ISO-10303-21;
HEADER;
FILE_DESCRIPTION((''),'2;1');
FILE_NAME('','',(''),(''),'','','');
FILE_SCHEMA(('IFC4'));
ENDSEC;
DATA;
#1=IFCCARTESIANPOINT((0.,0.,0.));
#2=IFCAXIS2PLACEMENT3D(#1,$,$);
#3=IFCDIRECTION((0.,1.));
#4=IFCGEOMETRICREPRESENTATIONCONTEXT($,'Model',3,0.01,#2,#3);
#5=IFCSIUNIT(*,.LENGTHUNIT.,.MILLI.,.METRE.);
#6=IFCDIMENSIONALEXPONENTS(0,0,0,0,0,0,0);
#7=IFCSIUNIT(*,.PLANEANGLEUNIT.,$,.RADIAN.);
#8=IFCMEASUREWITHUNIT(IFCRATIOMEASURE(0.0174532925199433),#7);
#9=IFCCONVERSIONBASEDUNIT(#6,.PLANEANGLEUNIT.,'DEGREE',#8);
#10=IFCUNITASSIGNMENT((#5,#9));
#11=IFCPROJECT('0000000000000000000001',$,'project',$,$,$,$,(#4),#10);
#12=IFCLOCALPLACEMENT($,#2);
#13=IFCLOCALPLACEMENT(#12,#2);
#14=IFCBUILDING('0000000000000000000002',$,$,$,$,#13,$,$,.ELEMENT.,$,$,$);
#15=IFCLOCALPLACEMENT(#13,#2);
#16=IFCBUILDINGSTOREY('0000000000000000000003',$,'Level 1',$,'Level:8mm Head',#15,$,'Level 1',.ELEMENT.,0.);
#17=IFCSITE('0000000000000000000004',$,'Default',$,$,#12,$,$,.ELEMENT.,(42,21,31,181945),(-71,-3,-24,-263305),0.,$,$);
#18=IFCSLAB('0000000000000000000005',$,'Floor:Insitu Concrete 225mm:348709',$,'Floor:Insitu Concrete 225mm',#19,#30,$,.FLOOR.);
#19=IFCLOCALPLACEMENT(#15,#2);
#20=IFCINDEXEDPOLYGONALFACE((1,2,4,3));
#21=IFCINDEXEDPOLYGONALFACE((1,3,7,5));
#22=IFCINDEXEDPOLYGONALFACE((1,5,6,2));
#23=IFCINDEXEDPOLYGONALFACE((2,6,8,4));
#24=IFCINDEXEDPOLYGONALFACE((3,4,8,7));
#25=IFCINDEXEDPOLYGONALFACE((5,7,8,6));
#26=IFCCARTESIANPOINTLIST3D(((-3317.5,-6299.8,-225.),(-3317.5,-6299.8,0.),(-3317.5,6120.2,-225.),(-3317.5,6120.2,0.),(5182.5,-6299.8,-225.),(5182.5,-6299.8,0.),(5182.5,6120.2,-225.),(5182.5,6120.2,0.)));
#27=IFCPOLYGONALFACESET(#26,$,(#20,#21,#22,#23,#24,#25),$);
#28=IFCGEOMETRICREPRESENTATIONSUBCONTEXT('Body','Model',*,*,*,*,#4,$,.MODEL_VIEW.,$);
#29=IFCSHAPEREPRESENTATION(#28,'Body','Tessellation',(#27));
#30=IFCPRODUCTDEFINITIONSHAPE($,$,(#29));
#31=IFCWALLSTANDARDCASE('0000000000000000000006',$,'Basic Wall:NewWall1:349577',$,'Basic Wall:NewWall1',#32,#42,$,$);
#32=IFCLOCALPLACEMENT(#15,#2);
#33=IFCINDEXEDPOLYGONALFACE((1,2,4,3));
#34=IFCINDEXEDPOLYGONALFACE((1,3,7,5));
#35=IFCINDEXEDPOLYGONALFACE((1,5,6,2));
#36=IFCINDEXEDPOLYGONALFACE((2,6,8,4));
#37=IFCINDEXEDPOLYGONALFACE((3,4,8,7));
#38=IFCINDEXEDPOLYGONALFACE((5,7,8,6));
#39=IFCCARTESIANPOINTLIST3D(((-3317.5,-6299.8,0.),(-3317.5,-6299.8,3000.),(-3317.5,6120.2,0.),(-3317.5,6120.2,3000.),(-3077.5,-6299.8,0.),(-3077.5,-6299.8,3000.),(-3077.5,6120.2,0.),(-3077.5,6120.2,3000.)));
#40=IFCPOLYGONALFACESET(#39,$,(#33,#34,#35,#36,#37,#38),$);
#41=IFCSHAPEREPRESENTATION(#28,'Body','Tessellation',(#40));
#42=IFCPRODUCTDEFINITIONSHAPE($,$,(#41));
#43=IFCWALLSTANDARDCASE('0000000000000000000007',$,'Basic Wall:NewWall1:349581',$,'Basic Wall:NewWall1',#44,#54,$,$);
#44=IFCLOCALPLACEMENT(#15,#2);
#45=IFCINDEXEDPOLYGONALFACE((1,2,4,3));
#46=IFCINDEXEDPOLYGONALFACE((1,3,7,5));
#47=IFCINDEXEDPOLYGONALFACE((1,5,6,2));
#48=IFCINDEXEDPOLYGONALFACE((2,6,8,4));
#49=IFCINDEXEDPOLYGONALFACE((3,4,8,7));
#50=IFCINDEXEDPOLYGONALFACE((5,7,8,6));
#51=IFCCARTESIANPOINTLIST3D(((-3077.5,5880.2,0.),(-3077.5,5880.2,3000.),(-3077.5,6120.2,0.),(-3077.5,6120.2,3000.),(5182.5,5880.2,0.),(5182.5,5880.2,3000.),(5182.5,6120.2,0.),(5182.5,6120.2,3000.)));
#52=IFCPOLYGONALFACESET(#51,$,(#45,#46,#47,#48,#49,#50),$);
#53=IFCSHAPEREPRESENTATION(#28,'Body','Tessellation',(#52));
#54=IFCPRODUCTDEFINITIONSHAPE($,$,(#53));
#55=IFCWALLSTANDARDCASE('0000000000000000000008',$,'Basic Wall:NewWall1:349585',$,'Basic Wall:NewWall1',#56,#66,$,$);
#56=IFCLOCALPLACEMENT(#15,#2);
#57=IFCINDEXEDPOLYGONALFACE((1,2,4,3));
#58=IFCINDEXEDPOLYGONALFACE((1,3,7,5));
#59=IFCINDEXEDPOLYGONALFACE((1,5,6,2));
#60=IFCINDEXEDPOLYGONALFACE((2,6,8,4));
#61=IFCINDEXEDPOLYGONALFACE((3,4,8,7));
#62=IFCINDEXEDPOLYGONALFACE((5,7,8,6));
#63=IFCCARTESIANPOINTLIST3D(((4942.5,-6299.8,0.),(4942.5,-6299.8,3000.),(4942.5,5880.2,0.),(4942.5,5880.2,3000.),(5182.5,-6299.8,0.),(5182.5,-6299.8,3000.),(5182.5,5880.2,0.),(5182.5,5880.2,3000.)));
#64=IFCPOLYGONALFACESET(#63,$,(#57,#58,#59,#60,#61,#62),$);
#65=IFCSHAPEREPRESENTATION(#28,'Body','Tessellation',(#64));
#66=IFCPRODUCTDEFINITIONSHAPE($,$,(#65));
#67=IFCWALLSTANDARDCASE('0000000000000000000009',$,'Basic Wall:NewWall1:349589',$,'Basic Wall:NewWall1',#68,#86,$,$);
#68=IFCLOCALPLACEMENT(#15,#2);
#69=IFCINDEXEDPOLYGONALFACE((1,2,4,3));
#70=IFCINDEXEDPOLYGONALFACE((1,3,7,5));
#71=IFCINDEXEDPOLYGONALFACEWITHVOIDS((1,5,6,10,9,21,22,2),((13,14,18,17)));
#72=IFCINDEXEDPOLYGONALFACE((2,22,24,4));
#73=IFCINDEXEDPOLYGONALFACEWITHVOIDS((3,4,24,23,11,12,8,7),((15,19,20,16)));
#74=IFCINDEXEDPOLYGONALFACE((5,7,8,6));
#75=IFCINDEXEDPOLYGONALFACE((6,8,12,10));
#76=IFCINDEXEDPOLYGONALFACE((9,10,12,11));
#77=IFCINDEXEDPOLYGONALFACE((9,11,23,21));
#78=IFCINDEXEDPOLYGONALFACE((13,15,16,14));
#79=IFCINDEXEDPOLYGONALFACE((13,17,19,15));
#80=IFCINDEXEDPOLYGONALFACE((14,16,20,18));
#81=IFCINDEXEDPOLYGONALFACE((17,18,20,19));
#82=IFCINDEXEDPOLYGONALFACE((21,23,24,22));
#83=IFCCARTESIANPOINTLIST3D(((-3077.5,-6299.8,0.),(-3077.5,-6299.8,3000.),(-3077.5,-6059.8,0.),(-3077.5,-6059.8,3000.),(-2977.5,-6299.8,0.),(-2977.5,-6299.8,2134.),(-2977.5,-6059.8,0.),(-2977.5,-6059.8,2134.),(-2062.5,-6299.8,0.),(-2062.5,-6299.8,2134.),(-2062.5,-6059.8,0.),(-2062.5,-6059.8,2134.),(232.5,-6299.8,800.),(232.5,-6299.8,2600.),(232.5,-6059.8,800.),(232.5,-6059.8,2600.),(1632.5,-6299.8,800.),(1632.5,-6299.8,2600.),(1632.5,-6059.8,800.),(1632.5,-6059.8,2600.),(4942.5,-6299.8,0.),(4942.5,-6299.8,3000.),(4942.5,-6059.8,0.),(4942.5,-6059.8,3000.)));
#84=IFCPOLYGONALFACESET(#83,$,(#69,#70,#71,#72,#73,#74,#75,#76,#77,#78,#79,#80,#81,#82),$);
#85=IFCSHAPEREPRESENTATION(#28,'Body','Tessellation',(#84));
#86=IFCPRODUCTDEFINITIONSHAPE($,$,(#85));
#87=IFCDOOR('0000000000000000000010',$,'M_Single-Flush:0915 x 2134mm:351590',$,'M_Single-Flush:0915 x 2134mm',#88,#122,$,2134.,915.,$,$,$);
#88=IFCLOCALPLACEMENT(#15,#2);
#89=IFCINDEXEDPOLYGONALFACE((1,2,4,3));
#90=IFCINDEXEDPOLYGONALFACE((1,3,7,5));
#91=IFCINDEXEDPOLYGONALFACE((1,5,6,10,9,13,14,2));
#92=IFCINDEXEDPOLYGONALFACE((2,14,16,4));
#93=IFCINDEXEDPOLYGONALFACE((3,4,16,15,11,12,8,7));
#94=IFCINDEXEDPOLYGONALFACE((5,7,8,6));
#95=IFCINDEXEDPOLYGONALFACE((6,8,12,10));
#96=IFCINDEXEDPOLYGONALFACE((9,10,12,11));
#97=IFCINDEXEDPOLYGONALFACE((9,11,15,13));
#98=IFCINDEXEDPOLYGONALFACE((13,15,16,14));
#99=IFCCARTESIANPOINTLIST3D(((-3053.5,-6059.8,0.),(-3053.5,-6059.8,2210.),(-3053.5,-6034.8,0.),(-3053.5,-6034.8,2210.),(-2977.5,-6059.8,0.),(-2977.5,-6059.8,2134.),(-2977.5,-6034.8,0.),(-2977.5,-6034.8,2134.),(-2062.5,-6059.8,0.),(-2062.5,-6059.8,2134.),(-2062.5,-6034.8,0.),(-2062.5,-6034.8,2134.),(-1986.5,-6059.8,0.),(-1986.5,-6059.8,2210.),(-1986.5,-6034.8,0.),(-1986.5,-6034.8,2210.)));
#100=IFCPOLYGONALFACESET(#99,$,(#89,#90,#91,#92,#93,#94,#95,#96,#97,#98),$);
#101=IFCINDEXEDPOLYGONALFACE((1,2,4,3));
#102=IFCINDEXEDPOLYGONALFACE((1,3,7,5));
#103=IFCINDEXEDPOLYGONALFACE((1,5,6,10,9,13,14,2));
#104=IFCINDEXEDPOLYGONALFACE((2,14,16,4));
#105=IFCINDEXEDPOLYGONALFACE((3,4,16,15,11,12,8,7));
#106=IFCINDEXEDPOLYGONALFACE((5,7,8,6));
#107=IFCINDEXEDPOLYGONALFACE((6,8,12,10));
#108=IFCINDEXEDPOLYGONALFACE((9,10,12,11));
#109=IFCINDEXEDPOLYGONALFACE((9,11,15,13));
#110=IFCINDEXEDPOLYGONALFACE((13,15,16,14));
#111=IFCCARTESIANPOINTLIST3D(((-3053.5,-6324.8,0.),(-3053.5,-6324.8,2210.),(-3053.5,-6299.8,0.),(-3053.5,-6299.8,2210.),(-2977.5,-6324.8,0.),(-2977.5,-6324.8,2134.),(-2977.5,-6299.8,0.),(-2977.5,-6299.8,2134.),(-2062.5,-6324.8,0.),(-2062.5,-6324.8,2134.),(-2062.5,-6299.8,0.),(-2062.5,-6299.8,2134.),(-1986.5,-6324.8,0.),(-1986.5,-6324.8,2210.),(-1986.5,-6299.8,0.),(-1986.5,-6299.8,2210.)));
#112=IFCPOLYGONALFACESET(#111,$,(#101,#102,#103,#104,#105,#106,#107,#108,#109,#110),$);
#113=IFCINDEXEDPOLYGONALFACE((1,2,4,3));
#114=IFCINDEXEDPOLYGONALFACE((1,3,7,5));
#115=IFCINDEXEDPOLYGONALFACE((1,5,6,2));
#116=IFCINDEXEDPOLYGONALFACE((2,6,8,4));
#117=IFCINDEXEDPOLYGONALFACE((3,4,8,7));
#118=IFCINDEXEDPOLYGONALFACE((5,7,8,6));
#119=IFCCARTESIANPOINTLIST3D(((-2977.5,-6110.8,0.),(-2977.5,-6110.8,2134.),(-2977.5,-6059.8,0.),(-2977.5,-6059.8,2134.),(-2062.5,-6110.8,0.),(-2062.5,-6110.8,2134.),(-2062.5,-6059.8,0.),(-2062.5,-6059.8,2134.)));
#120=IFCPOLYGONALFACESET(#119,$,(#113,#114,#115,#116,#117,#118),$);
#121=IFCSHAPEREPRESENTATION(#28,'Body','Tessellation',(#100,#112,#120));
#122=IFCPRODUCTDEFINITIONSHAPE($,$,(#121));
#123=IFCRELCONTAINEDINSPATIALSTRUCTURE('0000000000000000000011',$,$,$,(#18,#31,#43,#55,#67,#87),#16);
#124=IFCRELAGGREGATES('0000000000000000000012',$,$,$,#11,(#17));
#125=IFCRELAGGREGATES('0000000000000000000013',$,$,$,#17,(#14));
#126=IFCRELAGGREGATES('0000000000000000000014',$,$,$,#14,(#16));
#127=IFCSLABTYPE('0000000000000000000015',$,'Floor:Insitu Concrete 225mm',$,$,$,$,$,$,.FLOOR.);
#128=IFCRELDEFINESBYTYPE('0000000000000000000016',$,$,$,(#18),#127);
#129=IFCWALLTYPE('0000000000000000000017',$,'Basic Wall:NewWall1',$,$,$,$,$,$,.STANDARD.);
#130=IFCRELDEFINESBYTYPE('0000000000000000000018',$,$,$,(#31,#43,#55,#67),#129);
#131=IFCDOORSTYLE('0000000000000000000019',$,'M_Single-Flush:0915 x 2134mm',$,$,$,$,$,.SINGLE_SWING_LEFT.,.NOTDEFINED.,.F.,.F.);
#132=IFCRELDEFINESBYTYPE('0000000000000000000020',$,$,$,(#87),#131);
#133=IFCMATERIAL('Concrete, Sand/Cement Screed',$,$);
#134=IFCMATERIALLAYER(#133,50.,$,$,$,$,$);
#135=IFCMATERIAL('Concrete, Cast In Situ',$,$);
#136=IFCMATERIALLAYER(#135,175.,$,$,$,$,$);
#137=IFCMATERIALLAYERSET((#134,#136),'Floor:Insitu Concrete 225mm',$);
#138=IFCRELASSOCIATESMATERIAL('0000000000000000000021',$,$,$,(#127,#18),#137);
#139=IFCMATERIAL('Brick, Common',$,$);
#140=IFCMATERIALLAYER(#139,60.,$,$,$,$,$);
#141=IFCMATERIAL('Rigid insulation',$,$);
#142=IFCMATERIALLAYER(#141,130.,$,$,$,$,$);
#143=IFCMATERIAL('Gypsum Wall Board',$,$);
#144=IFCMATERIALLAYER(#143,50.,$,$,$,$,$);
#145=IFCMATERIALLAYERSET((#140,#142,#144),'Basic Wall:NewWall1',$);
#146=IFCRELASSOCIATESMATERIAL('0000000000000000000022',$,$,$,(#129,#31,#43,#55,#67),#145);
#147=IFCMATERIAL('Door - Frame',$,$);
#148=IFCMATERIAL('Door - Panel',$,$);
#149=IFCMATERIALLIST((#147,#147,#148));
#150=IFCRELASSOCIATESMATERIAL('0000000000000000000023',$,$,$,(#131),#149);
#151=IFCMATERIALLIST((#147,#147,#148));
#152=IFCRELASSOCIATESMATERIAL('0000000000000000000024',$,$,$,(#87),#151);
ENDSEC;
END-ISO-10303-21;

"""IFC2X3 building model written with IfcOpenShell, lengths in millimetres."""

from ifc_helpers import new_model, entity, si_unit, converted_unit, direction, frame, frame_2d, origin, place, context, subcontext, project, spatial, polyline, rectangle, outline, extrude, clip, bounded_halfspace, source, transform, mapped, material, material_list, layer, layer_set, layer_usage, type_object, type_shapes, element, fill, save


model = new_model("IFC2X3")

# Units and contexts
model_context = context("Model", 3, precision=0.01, world=origin(), true_north=direction((0.0, 1.0)))
body_context = subcontext(model_context, "Body", "Model", "MODEL_VIEW")
ifc_project = project(units=[si_unit("LENGTHUNIT", "METRE", prefix="MILLI"), converted_unit("PLANEANGLEUNIT", "DEGREE", entity("IfcRatioMeasure", 0.0174532925199433), si_unit("PLANEANGLEUNIT", "RADIAN"), dimensions=[0, 0, 0, 0, 0, 0, 0])], contexts=[model_context])

# Site, building, storey
site_placement = place(None, origin())
site = spatial("IfcSite", under=ifc_project, at=site_placement, Name="Default", CompositionType="ELEMENT", RefLatitude=(42, 21, 31, 181945), RefLongitude=(-71, -3, -24, -263305), RefElevation=0.0)
building_placement = place(site_placement, origin())
building = spatial("IfcBuilding", under=site, at=building_placement, CompositionType="ELEMENT")
storey_placement = place(building_placement, origin())
storey = spatial("IfcBuildingStorey", under=building, at=storey_placement, Name="Level 1", ObjectType="Level:8mm Head", LongName="Level 1", CompositionType="ELEMENT", Elevation=0.0)

# Slab
ifc_material_1 = material(Name="Concrete, Sand/Cement Screed")
ifc_layer_1 = layer(ifc_material_1, 50.0)
ifc_material_2 = material(Name="Concrete, Cast In Situ")
ifc_layer_2 = layer(ifc_material_2, 175.0)
ifc_layer_set_1 = layer_set([ifc_layer_1, ifc_layer_2], Name="Floor:Insitu Concrete 225mm")
ifc_layer_usage_1 = layer_usage(ifc_layer_set_1, "AXIS3", "POSITIVE", 0.0)
slab_type = type_object("IfcSlabType", Name="Floor:Insitu Concrete 225mm", PredefinedType="FLOOR", material=ifc_layer_set_1)
slab_placement = place(storey_placement, origin())
element("IfcSlab", 1, at=slab_placement, inside=storey, type_object=slab_type, material=ifc_layer_usage_1, Name="Floor:Insitu Concrete 225mm:348709", ObjectType="Floor:Insitu Concrete 225mm", PredefinedType="FLOOR", context=body_context, shape_type="SweptSolid", body=[
    extrude(rectangle(XDim=12420.0, YDim=8500.0, at=frame_2d((0.0, 0.0), x_axis=(1.0, 0.0))), frame((932.5, -89.8, 0.0), z_axis=(0.0, 0.0, -1.0), x_axis=(0.0, 1.0, 0.0)), (0.0, 0.0, 1.0), 225.0),
])

# Walls
ifc_material_3 = material(Name="Brick, Common")
ifc_layer_3 = layer(ifc_material_3, 60.0)
ifc_material_4 = material(Name="Rigid insulation")
ifc_layer_4 = layer(ifc_material_4, 130.0)
ifc_material_5 = material(Name="Gypsum Wall Board")
ifc_layer_5 = layer(ifc_material_5, 50.0)
ifc_layer_set_2 = layer_set([ifc_layer_3, ifc_layer_4, ifc_layer_5], Name="Basic Wall:NewWall1")
ifc_layer_usage_2 = layer_usage(ifc_layer_set_2, "AXIS2", "POSITIVE", -120.0)
wall_type_1 = type_object("IfcWallType", Name="Basic Wall:NewWall1", PredefinedType="STANDARD", material=ifc_layer_set_2)
wall_1_placement = place(storey_placement, frame((-3197.5, 6120.2, 0.0), z_axis=(0.0, 0.0, 1.0), x_axis=(0.0, -1.0, 0.0)))
element("IfcWallStandardCase", 2, at=wall_1_placement, inside=storey, type_object=wall_type_1, material=ifc_layer_usage_2, Name="Basic Wall:NewWall1:349577", ObjectType="Basic Wall:NewWall1", context=body_context, shape_type="Clipping", body=[
    clip(extrude(rectangle(XDim=12420.0, YDim=240.0, at=frame_2d((6210.0, 0.0), x_axis=(-1.0, 0.0))), origin(), (0.0, 0.0, 1.0), 3000.0), bounded_halfspace(frame((0.0, -120.0, 3000.0)), False, frame((0.0, -120.0, 3000.0)), polyline([(0.0, 0.0), (12420.0, 0.0), (12420.0, 240.0), (12180.0, 240.0), (6310.0, 240.0), (6110.0, 240.0), (240.0, 240.0), (0.0, 240.0), (0.0, 0.0)]))),
])
ifc_layer_usage_3 = layer_usage(ifc_layer_set_2, "AXIS2", "POSITIVE", -120.0)
wall_2_placement = place(storey_placement, frame((5182.5, 6000.2, 0.0), z_axis=(0.0, 0.0, 1.0), x_axis=(-1.0, 0.0, 0.0)))
element("IfcWallStandardCase", 3, at=wall_2_placement, inside=storey, type_object=wall_type_1, material=ifc_layer_usage_3, Name="Basic Wall:NewWall1:349581", ObjectType="Basic Wall:NewWall1", context=body_context, shape_type="Clipping", body=[
    clip(extrude(rectangle(XDim=8260.0, YDim=240.0, at=frame_2d((4130.0, 0.0), x_axis=(-1.0, 0.0))), origin(), (0.0, 0.0, 1.0), 3000.0), bounded_halfspace(frame((0.0, -120.0, 3000.0), z_axis=(0.0, 0.0, 1.0), x_axis=(0.0, 1.0, 0.0)), False, frame((0.0, -120.0, 3000.0)), polyline([(0.0, 0.0), (8260.0, 0.0), (8260.0, 240.0), (240.0, 240.0), (0.0, 240.0), (0.0, 0.0)]))),
])
ifc_layer_usage_4 = layer_usage(ifc_layer_set_2, "AXIS2", "POSITIVE", -120.0)
wall_3_placement = place(storey_placement, frame((5062.5, -6299.8, 0.0), z_axis=(0.0, 0.0, 1.0), x_axis=(0.0, 1.0, 0.0)))
element("IfcWallStandardCase", 4, at=wall_3_placement, inside=storey, type_object=wall_type_1, material=ifc_layer_usage_4, Name="Basic Wall:NewWall1:349585", ObjectType="Basic Wall:NewWall1", context=body_context, shape_type="Clipping", body=[
    clip(extrude(rectangle(XDim=12180.0, YDim=240.0, at=frame_2d((6090.0, 0.0), x_axis=(-1.0, 0.0))), origin(), (0.0, 0.0, 1.0), 3000.0), bounded_halfspace(frame((0.0, -120.0, 3000.0), z_axis=(0.0, 0.0, 1.0), x_axis=(-1.0, 0.0, 0.0)), False, frame((0.0, -120.0, 3000.0)), polyline([(0.0, 0.0), (12180.0, 0.0), (12180.0, 240.0), (6310.0, 240.0), (6110.0, 240.0), (240.0, 240.0), (0.0, 240.0), (0.0, 0.0)]))),
])

# Wall, openings, door
ifc_layer_usage_5 = layer_usage(ifc_layer_set_2, "AXIS2", "POSITIVE", -120.0)
wall_4_placement = place(storey_placement, frame((-3077.5, -6179.8, 0.0)))
wall_4 = element("IfcWallStandardCase", 5, at=wall_4_placement, inside=storey, type_object=wall_type_1, material=ifc_layer_usage_5, Name="Basic Wall:NewWall1:349589", ObjectType="Basic Wall:NewWall1", context=body_context, shape_type="Clipping", body=[
    clip(extrude(rectangle(XDim=8020.0, YDim=240.0, at=frame_2d((4010.0, 0.0), x_axis=(-1.0, 0.0))), origin(), (0.0, 0.0, 1.0), 3000.0), bounded_halfspace(frame((0.0, -120.0, 3000.0), z_axis=(0.0, 0.0, 1.0), x_axis=(0.0, -1.0, 0.0)), False, frame((0.0, -120.0, 3000.0)), polyline([(0.0, 0.0), (8020.0, 0.0), (8020.0, 240.0), (0.0, 240.0), (0.0, 0.0)]))),
])
opening_1_placement = place(wall_4_placement, frame((100.0, -120.0, 0.0)))
opening_1 = element("IfcOpeningElement", 6, at=opening_1_placement, cuts=wall_4, ObjectType="Opening", context=body_context, shape_type="SweptSolid", body=[
    extrude(rectangle(XDim=915.0, YDim=2134.0, at=frame_2d((1067.0, 457.5), x_axis=(0.0, -1.0))), frame((0.0, 0.0, 0.0), z_axis=(0.0, 1.0, 0.0), x_axis=(0.0, 0.0, 1.0)), (0.0, 0.0, 1.0), 240.0),
])
opening_2_placement = place(wall_4_placement, frame((4710.0, 120.0, 800.0)))
element("IfcOpeningElement", 7, at=opening_2_placement, cuts=wall_4, ObjectType="Opening", context=body_context, shape_type="SweptSolid", body=[
    extrude(rectangle(XDim=1800.0, YDim=1400.0, at=frame_2d((900.0, 700.0), x_axis=(-1.0, 0.0))), frame((0.0, 0.0, 0.0), z_axis=(0.0, -1.0, 0.0), x_axis=(0.0, 0.0, 1.0)), (0.0, 0.0, 1.0), 240.0),
])
ifc_material_6 = material(Name="Door - Frame")
ifc_material_7 = material(Name="Door - Panel")
ifc_material_list_1 = material_list([ifc_material_6, ifc_material_6, ifc_material_7])
ifc_material_list_2 = material_list([ifc_material_6, ifc_material_6, ifc_material_7])
door_style_1 = type_object("IfcDoorStyle", Name="M_Single-Flush:0915 x 2134mm", ConstructionType="NOTDEFINED", OperationType="SINGLE_SWING_LEFT", ParameterTakesPrecedence=False, Sizeable=False, material=ifc_material_list_2)
shared_shape_1 = source(origin(), body_context, "Body", "SweptSolid", [
    extrude(outline(polyline([(-533.5, -1124.0), (533.5, -1124.0), (533.5, 1086.0), (457.5, 1086.0), (457.5, -1048.0), (-457.5, -1048.0), (-457.5, 1086.0), (-533.5, 1086.0), (-533.5, -1124.0)])), frame((457.5, 265.0, 1086.0), z_axis=(0.0, -1.0, 0.0), x_axis=(-1.0, 0.0, 0.0)), (0.0, 0.0, 1.0), 25.0),
    extrude(outline(polyline([(-1124.0, -533.5), (1086.0, -533.5), (1086.0, -457.5), (-1048.0, -457.5), (-1048.0, 457.5), (1086.0, 457.5), (1086.0, 533.5), (-1124.0, 533.5), (-1124.0, -533.5)])), frame((457.5, 0.0, 1086.0), z_axis=(0.0, -1.0, 0.0), x_axis=(0.0, 0.0, -1.0)), (0.0, 0.0, 1.0), 25.0),
    extrude(rectangle(XDim=915.0, YDim=51.0, at=frame_2d((0.0, 0.0), x_axis=(1.0, 0.0))), frame((457.5, 214.5, 0.0)), (0.0, 0.0, 1.0), 2134.0),
])
type_shapes(door_style_1, [shared_shape_1])
door_1_placement = place(opening_1_placement, origin())
door_1 = element("IfcDoor", 8, at=door_1_placement, inside=storey, type_object=door_style_1, material=ifc_material_list_1, Name="M_Single-Flush:0915 x 2134mm:351590", ObjectType="M_Single-Flush:0915 x 2134mm", OverallHeight=2134.0, OverallWidth=915.0, context=body_context, shape_type="MappedRepresentation", body=[
    mapped(shared_shape_1, transform((0.0, 0.0, 0.0), scale=1.0)),
])
fill(opening_1, door_1)

save(model, "model.ifc")
